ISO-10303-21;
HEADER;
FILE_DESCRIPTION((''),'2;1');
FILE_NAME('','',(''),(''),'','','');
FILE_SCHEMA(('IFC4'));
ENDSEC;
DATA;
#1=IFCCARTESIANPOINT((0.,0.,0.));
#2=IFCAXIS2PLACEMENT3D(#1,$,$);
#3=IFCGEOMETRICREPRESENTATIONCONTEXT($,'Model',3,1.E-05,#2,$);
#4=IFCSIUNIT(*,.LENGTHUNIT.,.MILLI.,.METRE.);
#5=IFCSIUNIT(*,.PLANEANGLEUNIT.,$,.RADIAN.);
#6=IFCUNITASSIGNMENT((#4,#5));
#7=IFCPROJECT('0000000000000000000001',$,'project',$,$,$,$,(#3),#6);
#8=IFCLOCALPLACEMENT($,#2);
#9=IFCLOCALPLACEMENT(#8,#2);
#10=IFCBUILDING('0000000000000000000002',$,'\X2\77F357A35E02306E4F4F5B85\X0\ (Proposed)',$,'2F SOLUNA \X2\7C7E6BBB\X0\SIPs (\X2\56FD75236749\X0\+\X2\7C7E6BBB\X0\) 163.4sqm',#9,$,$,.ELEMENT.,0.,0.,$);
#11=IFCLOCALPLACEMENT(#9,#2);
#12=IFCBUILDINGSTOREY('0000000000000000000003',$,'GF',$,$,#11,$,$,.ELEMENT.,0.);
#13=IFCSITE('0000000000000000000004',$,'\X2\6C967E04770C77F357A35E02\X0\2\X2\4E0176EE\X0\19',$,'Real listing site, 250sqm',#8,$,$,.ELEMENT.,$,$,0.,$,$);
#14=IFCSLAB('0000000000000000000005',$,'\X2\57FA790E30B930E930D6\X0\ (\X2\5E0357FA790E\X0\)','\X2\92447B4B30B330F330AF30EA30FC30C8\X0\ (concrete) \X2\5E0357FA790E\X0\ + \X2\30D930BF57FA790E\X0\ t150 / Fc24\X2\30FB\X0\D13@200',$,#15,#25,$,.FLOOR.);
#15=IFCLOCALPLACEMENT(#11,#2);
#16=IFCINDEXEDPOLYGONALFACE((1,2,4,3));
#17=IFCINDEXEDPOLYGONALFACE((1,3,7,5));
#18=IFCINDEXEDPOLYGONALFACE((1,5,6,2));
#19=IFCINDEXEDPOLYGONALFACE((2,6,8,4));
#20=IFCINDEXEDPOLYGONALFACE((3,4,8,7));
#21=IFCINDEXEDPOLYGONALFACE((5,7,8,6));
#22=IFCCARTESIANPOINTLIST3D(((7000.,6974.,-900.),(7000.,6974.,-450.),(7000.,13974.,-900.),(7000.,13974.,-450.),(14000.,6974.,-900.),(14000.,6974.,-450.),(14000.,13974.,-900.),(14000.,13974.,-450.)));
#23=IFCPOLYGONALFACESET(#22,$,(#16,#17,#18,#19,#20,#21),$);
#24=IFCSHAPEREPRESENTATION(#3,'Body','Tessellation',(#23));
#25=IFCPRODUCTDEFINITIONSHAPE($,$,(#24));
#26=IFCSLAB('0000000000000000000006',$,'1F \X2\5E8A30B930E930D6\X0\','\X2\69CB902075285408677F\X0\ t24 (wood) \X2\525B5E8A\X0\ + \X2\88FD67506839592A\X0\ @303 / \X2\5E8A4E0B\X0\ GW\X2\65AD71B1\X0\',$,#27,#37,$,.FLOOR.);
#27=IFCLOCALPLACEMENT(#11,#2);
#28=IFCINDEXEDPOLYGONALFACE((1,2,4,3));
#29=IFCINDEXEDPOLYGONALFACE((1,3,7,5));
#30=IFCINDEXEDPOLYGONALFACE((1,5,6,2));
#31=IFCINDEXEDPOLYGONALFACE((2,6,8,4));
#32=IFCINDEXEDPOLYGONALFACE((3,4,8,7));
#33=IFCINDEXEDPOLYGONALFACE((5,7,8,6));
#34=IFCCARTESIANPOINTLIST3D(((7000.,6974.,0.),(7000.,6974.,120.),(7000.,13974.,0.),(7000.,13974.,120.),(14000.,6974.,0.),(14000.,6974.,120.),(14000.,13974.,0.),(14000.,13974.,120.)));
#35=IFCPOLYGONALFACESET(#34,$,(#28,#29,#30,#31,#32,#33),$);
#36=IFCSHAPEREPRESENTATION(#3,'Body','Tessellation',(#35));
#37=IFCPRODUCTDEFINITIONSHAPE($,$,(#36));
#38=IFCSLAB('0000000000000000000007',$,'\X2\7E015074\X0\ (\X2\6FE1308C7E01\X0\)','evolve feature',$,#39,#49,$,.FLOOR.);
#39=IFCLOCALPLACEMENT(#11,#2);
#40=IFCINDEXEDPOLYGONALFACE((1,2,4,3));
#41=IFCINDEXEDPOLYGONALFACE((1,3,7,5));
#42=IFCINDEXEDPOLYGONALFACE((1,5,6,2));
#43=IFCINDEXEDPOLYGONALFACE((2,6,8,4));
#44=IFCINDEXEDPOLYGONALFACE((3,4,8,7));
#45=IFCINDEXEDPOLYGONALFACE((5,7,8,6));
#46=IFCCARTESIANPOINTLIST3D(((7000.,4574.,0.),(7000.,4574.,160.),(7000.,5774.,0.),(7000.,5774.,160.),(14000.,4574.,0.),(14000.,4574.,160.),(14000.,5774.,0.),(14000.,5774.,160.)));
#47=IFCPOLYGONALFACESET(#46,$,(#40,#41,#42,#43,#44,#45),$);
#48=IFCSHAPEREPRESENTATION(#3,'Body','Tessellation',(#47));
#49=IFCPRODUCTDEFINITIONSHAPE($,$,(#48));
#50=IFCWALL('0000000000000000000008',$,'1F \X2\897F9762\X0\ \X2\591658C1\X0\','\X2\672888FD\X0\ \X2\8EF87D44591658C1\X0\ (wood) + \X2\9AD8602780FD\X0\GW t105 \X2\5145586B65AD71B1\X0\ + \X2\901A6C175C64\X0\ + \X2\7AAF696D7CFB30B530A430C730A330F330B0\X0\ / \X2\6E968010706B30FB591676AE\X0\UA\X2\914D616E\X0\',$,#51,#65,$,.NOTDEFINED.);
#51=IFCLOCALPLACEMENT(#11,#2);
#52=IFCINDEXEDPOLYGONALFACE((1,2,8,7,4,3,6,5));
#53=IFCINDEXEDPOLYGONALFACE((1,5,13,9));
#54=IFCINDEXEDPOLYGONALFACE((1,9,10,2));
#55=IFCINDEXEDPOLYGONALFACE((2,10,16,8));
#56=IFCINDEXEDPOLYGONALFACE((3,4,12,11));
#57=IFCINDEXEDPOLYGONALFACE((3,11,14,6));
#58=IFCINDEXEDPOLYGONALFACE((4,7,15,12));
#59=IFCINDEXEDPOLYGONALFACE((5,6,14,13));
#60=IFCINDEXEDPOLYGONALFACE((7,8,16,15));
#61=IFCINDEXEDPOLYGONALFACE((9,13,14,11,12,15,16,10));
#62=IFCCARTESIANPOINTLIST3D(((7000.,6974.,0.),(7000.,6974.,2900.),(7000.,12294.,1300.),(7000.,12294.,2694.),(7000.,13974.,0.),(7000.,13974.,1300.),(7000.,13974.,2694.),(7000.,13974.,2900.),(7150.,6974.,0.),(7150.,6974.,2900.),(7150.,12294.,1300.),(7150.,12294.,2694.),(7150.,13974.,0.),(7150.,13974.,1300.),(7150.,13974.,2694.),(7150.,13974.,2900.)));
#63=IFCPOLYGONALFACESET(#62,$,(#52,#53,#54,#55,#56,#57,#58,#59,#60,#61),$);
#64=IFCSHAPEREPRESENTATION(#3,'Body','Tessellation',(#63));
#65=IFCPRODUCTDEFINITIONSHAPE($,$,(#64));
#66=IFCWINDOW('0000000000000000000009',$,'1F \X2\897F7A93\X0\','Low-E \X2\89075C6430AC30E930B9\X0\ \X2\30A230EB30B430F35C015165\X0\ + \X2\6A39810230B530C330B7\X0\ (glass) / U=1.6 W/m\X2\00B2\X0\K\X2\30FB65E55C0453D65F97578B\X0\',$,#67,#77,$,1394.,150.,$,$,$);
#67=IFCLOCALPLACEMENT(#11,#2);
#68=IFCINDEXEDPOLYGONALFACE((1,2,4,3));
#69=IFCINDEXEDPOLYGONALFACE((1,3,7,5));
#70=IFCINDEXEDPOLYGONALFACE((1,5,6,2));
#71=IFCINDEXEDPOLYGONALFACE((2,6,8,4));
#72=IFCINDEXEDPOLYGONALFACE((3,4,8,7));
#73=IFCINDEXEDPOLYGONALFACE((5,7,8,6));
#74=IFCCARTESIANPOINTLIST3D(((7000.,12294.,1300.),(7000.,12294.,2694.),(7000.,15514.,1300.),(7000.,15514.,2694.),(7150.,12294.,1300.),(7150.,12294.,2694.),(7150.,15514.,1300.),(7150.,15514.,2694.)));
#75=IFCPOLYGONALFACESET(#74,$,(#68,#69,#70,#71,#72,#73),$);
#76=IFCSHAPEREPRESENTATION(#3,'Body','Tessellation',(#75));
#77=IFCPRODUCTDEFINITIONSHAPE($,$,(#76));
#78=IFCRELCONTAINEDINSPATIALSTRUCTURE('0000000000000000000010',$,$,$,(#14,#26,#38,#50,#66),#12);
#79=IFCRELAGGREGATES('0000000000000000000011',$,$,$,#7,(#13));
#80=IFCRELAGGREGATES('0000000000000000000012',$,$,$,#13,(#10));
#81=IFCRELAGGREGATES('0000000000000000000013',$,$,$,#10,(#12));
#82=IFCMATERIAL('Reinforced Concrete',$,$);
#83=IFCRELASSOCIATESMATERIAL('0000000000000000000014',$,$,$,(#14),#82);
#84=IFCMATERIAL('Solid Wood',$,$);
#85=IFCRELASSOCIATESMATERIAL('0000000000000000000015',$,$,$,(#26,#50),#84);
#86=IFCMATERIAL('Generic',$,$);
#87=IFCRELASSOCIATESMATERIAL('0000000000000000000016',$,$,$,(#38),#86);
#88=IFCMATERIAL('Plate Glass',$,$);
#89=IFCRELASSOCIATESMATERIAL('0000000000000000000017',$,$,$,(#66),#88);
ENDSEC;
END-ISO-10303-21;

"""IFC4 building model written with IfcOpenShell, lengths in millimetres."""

from ifc_helpers import new_model, si_unit, frame, frame_2d, origin, place, context, project, spatial, rectangle, extrude, material, element, fill, save


model = new_model("IFC4")

# Units and contexts
model_context = context("Model", 3, precision=1e-05, world=origin())
ifc_project = project(units=[si_unit("LENGTHUNIT", "METRE", prefix="MILLI"), si_unit("PLANEANGLEUNIT", "RADIAN")], contexts=[model_context])

# Site, building, storey
site_placement = place(None, origin())
site = spatial("IfcSite", under=ifc_project, at=site_placement, Name="沖縄県石垣市2丁目19", ObjectType="Real listing site, 250sqm", CompositionType="ELEMENT", RefElevation=0.0)
building_placement = place(site_placement, origin())
building = spatial("IfcBuilding", under=site, at=building_placement, Name="石垣市の住宅 (Proposed)", ObjectType="2F SOLUNA 籾殻SIPs (国産杉+籾殻) 163.4sqm", CompositionType="ELEMENT", ElevationOfRefHeight=0.0, ElevationOfTerrain=0.0)
storey_placement = place(building_placement, origin())
storey = spatial("IfcBuildingStorey", under=building, at=storey_placement, Name="GF", CompositionType="ELEMENT", Elevation=0.0)

# Slabs
ifc_material_1 = material(Name="Reinforced Concrete")
slab_1_placement = place(storey_placement, frame((3500.0, 3487.0, -450.0)))
element("IfcSlab", 1, at=slab_1_placement, inside=storey, material=ifc_material_1, Name="基礎スラブ (布基礎)", Description="鉄筋コンクリート (concrete) 布基礎 + ベタ基礎 t150 / Fc24・D13@200", PredefinedType="FLOOR", context=model_context, shape_type="SweptSolid", body=[
    extrude(rectangle(XDim=7000.0, YDim=7000.0, at=frame_2d((3500.0, 3500.0))), frame((3500.0, 3487.0, -450.0)), (0.0, 0.0, 1.0), 450.0),
])
ifc_material_2 = material(Name="Solid Wood")
slab_2_placement = place(storey_placement, frame((3500.0, 3487.0, 0.0)))
element("IfcSlab", 2, at=slab_2_placement, inside=storey, material=ifc_material_2, Name="1F 床スラブ", Description="構造用合板 t24 (wood) 剛床 + 製材根太 @303 / 床下 GW断熱", PredefinedType="FLOOR", context=model_context, shape_type="SweptSolid", body=[
    extrude(rectangle(XDim=7000.0, YDim=7000.0, at=frame_2d((3500.0, 3500.0))), frame((3500.0, 3487.0, 0.0)), (0.0, 0.0, 1.0), 120.0),
])
ifc_material_3 = material(Name="Generic")
slab_3_placement = place(storey_placement, frame((3500.0, 2287.0, 0.0)))
element("IfcSlab", 3, at=slab_3_placement, inside=storey, material=ifc_material_3, Name="縁側 (濡れ縁)", Description="evolve feature", PredefinedType="FLOOR", context=model_context, shape_type="SweptSolid", body=[
    extrude(rectangle(XDim=7000.0, YDim=1200.0, at=frame_2d((3500.0, 600.0))), frame((3500.0, 2287.0, 0.0)), (0.0, 0.0, 1.0), 160.0),
])

# Shared definitions
ifc_material_4 = material(Name="Plate Glass")

# Wall, opening, window
wall_1_placement = place(storey_placement, frame((3500.0, 3487.0, 0.0)))
wall_1 = element("IfcWall", 4, at=wall_1_placement, inside=storey, material=ifc_material_2, Name="1F 西面 外壁", Description="木製 軸組外壁 (wood) + 高性能GW t105 充填断熱 + 通気層 + 窯業系サイディング / 準耐火・外皮UA配慮", PredefinedType="NOTDEFINED", context=model_context, shape_type="SweptSolid", body=[
    extrude(rectangle(XDim=150.0, YDim=7000.0, at=frame_2d((75.0, 3500.0))), frame((3500.0, 3487.0, 0.0)), (0.0, 0.0, 1.0), 2900.0),
])
opening_1_placement = place(storey_placement, frame((3500.0, 6147.0, 650.0)))
opening_1 = element("IfcOpeningElement", 5, at=opening_1_placement, cuts=wall_1, PredefinedType="NOTDEFINED", context=model_context, shape_type="SweptSolid", body=[
    extrude(rectangle(XDim=150.0, YDim=3220.0, at=frame_2d((75.0, 1610.0))), frame((3500.0, 6147.0, 650.0)), (0.0, 0.0, 1.0), 1394.0),
])
window_1_placement = place(storey_placement, frame((3500.0, 6147.0, 650.0)))
window_1 = element("IfcWindow", 6, at=window_1_placement, inside=storey, material=ifc_material_4, Name="1F 西窓", Description="Low-E 複層ガラス アルゴン封入 + 樹脂サッシ (glass) / U=1.6 W/m²K・日射取得型", OverallHeight=1394.0, OverallWidth=150.0, context=model_context, shape_type="SweptSolid", body=[
    extrude(rectangle(XDim=150.0, YDim=3220.0, at=frame_2d((75.0, 1610.0))), frame((3500.0, 6147.0, 650.0)), (0.0, 0.0, 1.0), 1394.0),
])
fill(opening_1, window_1)

save(model, "model.ifc")
